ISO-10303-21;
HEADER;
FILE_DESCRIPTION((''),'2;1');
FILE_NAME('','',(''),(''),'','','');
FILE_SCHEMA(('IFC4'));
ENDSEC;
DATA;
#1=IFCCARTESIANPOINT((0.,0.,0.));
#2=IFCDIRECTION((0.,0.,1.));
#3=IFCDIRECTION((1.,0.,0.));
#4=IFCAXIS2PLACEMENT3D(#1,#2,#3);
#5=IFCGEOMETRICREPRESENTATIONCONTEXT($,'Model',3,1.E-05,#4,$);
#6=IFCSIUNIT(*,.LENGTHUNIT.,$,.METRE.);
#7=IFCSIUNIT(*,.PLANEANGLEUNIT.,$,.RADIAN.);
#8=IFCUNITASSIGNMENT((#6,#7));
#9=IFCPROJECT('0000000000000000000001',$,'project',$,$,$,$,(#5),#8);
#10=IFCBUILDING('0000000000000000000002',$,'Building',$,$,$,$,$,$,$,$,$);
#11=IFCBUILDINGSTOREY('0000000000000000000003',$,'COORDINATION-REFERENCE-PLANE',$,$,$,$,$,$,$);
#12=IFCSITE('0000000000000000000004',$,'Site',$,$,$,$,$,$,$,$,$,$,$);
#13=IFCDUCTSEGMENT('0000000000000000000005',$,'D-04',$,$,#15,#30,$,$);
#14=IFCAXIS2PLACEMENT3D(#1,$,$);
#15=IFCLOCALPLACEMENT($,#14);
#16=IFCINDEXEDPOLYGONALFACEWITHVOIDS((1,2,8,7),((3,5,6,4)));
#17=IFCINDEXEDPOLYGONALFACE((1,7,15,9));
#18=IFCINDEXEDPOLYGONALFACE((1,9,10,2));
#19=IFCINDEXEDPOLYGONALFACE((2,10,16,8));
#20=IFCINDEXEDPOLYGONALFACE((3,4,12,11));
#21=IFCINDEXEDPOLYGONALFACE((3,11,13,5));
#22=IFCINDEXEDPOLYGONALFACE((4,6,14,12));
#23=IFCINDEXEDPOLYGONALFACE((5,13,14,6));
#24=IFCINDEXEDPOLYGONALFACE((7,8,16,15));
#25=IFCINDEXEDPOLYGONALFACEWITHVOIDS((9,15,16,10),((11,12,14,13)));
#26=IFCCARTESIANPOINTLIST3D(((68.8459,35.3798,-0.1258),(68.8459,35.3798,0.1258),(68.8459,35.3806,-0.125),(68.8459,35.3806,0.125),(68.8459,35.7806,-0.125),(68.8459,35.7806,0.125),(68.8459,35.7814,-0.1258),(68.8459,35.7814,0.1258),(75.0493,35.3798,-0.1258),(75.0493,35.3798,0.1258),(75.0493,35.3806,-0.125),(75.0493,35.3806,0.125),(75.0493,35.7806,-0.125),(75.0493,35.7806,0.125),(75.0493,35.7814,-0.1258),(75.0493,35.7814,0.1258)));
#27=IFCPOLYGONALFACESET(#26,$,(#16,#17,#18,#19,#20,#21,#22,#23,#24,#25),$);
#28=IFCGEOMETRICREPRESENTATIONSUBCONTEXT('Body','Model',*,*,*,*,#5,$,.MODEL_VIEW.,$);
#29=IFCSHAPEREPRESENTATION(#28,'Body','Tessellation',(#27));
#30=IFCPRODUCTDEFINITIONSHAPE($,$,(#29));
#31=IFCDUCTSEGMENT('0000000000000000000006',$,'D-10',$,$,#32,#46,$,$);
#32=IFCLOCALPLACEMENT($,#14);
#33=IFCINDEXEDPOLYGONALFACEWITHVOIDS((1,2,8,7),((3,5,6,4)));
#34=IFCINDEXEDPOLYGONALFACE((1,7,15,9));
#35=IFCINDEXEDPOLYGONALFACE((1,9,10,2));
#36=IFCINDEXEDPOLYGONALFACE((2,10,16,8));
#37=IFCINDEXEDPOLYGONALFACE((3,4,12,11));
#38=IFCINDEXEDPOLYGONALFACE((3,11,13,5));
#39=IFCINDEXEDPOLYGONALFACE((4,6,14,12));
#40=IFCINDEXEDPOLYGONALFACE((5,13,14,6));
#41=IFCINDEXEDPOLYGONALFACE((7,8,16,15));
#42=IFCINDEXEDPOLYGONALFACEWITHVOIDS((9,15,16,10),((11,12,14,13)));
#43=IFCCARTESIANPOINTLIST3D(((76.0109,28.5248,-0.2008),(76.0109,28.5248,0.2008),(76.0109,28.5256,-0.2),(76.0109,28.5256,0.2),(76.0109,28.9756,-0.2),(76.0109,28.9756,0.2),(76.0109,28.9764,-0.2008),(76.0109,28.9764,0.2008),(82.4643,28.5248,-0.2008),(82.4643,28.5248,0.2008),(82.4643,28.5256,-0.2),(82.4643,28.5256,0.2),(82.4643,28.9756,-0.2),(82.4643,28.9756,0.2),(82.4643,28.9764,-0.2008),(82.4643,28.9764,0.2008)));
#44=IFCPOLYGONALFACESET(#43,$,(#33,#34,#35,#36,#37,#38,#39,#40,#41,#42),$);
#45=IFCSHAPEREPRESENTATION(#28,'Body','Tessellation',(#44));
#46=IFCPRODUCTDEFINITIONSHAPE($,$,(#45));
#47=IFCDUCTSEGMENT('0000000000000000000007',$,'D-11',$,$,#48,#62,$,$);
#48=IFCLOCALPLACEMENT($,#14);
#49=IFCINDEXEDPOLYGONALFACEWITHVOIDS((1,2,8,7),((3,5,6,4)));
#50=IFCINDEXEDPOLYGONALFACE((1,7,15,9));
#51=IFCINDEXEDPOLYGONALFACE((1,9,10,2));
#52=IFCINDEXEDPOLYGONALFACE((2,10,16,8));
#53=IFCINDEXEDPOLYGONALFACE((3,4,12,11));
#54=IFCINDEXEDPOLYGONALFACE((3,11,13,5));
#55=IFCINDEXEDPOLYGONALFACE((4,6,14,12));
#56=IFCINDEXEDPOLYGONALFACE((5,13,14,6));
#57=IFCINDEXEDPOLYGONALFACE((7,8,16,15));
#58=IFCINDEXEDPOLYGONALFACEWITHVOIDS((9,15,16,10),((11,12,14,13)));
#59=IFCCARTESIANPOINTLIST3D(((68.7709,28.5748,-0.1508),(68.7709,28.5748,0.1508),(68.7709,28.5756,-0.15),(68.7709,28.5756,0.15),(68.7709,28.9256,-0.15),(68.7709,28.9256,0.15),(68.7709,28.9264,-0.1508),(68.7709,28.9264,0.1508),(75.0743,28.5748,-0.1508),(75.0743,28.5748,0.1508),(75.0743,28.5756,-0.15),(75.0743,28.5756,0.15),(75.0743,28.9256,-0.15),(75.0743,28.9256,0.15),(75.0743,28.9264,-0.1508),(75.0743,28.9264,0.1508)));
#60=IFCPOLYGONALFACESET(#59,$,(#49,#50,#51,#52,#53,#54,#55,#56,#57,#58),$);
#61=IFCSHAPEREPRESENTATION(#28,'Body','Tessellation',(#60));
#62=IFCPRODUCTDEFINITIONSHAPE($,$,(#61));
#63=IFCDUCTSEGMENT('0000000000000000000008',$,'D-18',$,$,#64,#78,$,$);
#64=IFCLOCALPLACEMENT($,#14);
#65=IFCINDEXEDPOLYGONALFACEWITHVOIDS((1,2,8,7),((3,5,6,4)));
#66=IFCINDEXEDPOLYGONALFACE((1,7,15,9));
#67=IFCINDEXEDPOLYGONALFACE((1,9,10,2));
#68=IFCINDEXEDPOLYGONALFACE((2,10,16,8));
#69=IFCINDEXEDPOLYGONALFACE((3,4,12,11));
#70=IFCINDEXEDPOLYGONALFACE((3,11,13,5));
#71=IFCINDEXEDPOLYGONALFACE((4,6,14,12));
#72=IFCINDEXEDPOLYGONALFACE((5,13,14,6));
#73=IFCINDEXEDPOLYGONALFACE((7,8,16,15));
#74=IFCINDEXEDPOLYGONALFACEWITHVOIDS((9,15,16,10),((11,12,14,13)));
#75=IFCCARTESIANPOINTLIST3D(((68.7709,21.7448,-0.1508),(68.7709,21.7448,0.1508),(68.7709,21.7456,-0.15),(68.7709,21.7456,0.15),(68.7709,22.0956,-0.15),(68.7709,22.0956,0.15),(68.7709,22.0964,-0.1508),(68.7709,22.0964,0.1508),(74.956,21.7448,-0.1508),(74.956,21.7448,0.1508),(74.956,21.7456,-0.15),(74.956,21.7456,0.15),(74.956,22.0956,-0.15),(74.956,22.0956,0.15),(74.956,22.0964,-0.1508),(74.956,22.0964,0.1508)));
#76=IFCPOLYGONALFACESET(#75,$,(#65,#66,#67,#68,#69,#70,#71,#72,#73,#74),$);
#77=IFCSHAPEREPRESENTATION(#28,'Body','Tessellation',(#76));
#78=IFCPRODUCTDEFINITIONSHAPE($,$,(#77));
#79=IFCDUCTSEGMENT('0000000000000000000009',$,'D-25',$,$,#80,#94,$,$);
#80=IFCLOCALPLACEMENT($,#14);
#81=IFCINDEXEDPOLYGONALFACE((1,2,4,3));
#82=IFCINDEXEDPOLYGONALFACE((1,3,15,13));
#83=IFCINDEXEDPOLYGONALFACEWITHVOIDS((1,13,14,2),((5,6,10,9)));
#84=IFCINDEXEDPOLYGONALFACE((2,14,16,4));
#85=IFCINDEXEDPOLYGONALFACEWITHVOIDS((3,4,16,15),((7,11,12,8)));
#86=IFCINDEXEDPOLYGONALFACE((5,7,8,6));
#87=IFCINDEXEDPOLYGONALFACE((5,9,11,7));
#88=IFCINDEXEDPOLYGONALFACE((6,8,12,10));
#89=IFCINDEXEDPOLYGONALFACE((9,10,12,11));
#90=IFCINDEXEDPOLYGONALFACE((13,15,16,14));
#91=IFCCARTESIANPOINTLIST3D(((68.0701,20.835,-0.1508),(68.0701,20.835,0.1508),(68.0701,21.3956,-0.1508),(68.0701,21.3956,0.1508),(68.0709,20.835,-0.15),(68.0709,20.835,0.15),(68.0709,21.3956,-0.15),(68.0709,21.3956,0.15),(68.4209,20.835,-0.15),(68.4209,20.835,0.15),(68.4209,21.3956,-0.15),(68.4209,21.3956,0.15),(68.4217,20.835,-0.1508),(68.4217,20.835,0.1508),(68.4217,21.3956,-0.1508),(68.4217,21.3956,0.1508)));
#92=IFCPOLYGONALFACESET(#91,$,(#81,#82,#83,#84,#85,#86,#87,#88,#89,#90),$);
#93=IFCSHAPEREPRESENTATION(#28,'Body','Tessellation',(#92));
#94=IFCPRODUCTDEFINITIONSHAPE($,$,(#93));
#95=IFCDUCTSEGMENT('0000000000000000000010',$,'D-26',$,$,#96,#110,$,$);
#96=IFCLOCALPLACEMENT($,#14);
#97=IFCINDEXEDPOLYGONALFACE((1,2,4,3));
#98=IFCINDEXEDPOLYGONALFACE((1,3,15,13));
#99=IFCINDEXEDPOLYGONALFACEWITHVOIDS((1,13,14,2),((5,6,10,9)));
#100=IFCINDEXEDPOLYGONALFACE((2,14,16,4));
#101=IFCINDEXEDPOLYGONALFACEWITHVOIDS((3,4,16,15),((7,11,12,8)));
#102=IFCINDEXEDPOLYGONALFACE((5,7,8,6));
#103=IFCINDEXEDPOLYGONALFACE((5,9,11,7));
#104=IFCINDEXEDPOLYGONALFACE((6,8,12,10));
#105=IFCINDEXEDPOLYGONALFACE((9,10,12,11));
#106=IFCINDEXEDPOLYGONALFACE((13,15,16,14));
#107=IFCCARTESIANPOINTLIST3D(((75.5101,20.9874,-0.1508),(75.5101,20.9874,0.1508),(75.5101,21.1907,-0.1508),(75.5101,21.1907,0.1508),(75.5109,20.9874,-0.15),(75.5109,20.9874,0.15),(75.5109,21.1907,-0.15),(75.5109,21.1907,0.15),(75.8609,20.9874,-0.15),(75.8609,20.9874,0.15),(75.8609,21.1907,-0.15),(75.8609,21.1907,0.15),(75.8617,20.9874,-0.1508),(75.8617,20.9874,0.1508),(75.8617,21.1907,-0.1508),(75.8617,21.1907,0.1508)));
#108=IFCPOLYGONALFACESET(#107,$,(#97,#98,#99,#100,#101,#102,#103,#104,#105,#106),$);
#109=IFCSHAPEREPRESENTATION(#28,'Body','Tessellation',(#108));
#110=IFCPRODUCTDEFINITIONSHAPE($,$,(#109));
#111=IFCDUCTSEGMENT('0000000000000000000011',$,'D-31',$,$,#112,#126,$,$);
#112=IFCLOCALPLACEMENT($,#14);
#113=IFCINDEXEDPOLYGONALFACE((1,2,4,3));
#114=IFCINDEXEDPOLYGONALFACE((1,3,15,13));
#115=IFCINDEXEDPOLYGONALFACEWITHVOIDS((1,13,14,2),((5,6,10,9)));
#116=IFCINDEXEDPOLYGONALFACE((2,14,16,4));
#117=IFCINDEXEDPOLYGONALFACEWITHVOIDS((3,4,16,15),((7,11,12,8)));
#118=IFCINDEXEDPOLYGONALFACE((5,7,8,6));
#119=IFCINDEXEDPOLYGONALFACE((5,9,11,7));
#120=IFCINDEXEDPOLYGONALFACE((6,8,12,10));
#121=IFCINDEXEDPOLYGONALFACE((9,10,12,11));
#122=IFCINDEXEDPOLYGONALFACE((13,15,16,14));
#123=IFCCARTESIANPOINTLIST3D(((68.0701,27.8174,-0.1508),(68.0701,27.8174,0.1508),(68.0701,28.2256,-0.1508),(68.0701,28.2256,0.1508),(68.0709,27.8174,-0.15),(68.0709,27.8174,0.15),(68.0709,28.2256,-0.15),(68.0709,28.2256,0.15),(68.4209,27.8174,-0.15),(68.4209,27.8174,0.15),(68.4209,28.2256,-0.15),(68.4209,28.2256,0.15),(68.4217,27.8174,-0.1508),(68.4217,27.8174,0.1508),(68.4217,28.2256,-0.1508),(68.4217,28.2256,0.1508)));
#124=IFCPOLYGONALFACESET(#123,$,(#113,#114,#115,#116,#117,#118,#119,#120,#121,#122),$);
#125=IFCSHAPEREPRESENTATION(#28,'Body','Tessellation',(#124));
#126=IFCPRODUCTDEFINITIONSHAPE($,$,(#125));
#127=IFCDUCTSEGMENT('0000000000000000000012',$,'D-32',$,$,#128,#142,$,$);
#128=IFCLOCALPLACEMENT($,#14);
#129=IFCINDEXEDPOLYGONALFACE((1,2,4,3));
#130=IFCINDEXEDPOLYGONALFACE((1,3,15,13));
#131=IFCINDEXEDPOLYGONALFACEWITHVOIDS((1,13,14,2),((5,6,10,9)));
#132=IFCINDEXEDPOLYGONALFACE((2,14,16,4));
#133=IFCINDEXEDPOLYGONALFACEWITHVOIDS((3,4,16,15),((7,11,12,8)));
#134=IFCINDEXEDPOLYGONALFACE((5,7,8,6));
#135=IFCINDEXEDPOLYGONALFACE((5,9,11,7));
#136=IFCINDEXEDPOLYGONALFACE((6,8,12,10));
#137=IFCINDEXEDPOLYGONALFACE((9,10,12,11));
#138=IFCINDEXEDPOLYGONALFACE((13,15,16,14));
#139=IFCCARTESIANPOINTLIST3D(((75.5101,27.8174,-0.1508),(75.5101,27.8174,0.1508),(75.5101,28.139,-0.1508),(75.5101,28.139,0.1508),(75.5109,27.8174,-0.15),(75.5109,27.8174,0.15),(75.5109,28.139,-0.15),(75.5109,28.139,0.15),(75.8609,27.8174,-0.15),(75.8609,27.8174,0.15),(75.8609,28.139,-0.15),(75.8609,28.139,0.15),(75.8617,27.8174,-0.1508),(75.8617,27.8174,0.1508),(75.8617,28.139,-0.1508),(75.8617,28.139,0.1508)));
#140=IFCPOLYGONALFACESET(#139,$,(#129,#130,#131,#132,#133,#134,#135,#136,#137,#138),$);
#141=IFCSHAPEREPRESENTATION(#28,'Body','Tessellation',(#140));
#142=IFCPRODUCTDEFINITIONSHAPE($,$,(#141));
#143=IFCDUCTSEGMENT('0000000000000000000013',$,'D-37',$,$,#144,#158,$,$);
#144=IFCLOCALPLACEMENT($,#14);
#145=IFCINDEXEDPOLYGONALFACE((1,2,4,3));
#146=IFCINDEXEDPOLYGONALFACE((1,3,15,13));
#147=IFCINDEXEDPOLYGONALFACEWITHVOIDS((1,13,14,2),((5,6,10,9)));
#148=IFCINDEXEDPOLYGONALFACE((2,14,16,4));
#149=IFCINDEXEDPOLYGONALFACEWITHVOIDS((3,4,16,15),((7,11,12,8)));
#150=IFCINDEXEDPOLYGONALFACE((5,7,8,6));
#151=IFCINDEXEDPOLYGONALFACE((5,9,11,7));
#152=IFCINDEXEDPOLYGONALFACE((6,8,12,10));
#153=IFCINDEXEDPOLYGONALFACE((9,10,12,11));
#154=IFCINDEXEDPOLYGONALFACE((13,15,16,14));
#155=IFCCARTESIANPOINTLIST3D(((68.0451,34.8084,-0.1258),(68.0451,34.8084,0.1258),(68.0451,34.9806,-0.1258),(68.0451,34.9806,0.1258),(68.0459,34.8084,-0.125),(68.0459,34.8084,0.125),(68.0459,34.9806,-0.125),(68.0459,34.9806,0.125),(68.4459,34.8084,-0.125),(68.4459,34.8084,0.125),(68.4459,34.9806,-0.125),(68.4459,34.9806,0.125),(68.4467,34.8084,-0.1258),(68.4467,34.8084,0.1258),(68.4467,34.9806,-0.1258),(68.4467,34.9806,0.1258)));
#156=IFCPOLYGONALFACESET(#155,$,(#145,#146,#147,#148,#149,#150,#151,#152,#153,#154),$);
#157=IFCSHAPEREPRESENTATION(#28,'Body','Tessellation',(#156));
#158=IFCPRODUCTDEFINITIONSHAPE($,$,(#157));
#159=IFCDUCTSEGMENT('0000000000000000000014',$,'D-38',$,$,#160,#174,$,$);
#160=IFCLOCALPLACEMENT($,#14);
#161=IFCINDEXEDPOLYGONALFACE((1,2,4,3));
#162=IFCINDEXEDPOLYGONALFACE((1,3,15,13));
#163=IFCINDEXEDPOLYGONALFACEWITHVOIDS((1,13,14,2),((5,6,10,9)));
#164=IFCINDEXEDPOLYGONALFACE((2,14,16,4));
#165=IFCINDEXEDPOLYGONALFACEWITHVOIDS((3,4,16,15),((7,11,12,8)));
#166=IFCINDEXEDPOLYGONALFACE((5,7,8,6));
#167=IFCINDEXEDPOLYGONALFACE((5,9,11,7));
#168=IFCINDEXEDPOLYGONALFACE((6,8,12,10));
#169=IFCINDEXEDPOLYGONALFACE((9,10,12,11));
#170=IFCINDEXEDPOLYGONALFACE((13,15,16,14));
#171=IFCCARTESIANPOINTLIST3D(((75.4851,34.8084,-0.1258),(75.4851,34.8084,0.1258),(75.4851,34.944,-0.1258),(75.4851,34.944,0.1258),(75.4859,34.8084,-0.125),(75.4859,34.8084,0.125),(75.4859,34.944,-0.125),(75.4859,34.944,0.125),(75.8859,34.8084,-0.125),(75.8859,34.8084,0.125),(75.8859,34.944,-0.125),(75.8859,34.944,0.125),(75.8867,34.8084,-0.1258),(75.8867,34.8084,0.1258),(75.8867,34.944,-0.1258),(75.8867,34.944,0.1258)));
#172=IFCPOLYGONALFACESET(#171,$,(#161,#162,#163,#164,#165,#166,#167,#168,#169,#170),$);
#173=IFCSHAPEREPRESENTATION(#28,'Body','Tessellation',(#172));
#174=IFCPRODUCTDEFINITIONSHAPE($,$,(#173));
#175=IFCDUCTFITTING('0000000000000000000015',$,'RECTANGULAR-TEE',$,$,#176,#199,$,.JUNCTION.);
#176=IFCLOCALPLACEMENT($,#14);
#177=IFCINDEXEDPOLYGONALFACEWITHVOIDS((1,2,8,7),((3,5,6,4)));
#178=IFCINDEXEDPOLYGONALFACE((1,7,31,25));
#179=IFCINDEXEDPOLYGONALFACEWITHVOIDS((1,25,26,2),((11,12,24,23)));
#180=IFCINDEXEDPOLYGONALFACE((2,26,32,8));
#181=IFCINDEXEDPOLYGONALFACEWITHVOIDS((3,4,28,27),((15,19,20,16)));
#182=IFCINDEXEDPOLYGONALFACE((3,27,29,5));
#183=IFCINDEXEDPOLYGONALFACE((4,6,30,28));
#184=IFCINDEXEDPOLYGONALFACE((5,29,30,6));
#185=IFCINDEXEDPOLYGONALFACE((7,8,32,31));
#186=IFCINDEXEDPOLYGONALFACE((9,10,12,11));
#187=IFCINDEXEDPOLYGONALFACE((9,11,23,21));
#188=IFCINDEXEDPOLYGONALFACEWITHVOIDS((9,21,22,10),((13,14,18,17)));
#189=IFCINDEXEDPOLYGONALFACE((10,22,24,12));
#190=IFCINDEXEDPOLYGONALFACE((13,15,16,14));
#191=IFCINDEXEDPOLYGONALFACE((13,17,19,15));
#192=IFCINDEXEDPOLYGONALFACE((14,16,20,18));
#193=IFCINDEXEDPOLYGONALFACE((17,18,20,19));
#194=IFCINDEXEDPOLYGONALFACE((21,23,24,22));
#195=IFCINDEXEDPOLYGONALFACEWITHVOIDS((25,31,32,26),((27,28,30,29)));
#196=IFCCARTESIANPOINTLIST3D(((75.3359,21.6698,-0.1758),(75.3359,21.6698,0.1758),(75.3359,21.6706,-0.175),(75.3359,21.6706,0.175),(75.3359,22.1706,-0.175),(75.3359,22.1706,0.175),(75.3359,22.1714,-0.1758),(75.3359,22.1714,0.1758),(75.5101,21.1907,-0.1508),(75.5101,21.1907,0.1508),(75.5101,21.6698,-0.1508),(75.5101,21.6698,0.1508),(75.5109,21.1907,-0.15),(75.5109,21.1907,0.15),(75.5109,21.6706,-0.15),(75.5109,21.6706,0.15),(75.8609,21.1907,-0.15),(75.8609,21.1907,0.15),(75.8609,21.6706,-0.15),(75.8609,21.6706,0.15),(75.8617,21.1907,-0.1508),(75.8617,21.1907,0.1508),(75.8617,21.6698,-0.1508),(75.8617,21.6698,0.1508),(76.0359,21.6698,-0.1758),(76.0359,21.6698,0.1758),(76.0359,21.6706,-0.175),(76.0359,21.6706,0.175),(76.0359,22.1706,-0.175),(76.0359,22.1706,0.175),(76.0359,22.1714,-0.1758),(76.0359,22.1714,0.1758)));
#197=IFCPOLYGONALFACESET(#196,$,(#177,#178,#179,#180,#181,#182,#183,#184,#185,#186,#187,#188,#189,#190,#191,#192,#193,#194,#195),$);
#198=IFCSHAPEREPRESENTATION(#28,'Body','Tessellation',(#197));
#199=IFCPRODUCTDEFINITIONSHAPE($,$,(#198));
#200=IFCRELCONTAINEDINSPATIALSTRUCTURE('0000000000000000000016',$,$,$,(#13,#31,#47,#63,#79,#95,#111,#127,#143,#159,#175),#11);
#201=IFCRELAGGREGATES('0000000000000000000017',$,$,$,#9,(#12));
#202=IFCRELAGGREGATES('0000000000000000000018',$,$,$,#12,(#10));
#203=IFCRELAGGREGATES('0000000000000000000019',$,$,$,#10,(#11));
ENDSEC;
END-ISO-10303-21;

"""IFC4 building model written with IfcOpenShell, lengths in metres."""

from ifc_helpers import new_model, si_unit, frame, origin, origin_with_axes, place, context, subcontext, project, spatial, rectangle, hollow_rectangle, extrude, boolean, element, save


model = new_model("IFC4")

# Units and contexts
model_context = context("Model", 3, precision=1e-05, world=origin_with_axes())
body_context_1 = subcontext(model_context, "Body", "Model", "MODEL_VIEW")
ifc_project = project(units=[si_unit("LENGTHUNIT", "METRE"), si_unit("PLANEANGLEUNIT", "RADIAN")], contexts=[model_context])

# Site, building, storey
site = spatial("IfcSite", under=ifc_project, Name="Site")
building = spatial("IfcBuilding", under=site, Name="Building")
storey = spatial("IfcBuildingStorey", under=building, Name="COORDINATION-REFERENCE-PLANE")

# Duct segments
duct_segment_1_placement = place(None, frame((68.8459, 35.5806, 0.0), z_axis=(1.0, 0.0, 0.0), x_axis=(0.0, 1.0, 0.0)))
element("IfcDuctSegment", 1, at=duct_segment_1_placement, inside=storey, Name="D-04", context=body_context_1, shape_type="SweptSolid", body=[
    extrude(hollow_rectangle(XDim=0.4016, YDim=0.2516, WallThickness=0.0008), origin(), (0.0, 0.0, 1.0), 6.2034),
])
duct_segment_2_placement = place(None, frame((76.0109, 28.7506, 0.0), z_axis=(1.0, 0.0, 0.0), x_axis=(0.0, 1.0, 0.0)))
element("IfcDuctSegment", 2, at=duct_segment_2_placement, inside=storey, Name="D-10", context=body_context_1, shape_type="SweptSolid", body=[
    extrude(hollow_rectangle(XDim=0.4516, YDim=0.4016, WallThickness=0.0008), origin(), (0.0, 0.0, 1.0), 6.4534),
])
duct_segment_3_placement = place(None, frame((68.7709, 28.7506, 0.0), z_axis=(1.0, 0.0, 0.0), x_axis=(0.0, 1.0, 0.0)))
element("IfcDuctSegment", 3, at=duct_segment_3_placement, inside=storey, Name="D-11", context=body_context_1, shape_type="SweptSolid", body=[
    extrude(hollow_rectangle(XDim=0.3516, YDim=0.3016, WallThickness=0.0008), origin(), (0.0, 0.0, 1.0), 6.3034),
])
duct_segment_4_placement = place(None, frame((68.7709, 21.9206, 0.0), z_axis=(1.0, 0.0, 0.0), x_axis=(0.0, 1.0, 0.0)))
element("IfcDuctSegment", 4, at=duct_segment_4_placement, inside=storey, Name="D-18", context=body_context_1, shape_type="SweptSolid", body=[
    extrude(hollow_rectangle(XDim=0.3516, YDim=0.3016, WallThickness=0.0008), origin(), (0.0, 0.0, 1.0), 6.1851),
])
duct_segment_5_placement = place(None, frame((68.2459, 20.835, 0.0), z_axis=(0.0, 1.0, 0.0), x_axis=(1.0, 0.0, 0.0)))
element("IfcDuctSegment", 5, at=duct_segment_5_placement, inside=storey, Name="D-25", context=body_context_1, shape_type="SweptSolid", body=[
    extrude(hollow_rectangle(XDim=0.3516, YDim=0.3016, WallThickness=0.0008), origin(), (0.0, 0.0, 1.0), 0.5606),
])
duct_segment_6_placement = place(None, frame((75.6859, 20.9874, 0.0), z_axis=(0.0, 1.0, 0.0), x_axis=(1.0, 0.0, 0.0)))
element("IfcDuctSegment", 6, at=duct_segment_6_placement, inside=storey, Name="D-26", context=body_context_1, shape_type="SweptSolid", body=[
    extrude(hollow_rectangle(XDim=0.3516, YDim=0.3016, WallThickness=0.0008), origin(), (0.0, 0.0, 1.0), 0.2033),
])
duct_segment_7_placement = place(None, frame((68.2459, 27.8174, 0.0), z_axis=(0.0, 1.0, 0.0), x_axis=(1.0, 0.0, 0.0)))
element("IfcDuctSegment", 7, at=duct_segment_7_placement, inside=storey, Name="D-31", context=body_context_1, shape_type="SweptSolid", body=[
    extrude(hollow_rectangle(XDim=0.3516, YDim=0.3016, WallThickness=0.0008), origin(), (0.0, 0.0, 1.0), 0.4082),
])
duct_segment_8_placement = place(None, frame((75.6859, 27.8174, 0.0), z_axis=(0.0, 1.0, 0.0), x_axis=(1.0, 0.0, 0.0)))
element("IfcDuctSegment", 8, at=duct_segment_8_placement, inside=storey, Name="D-32", context=body_context_1, shape_type="SweptSolid", body=[
    extrude(hollow_rectangle(XDim=0.3516, YDim=0.3016, WallThickness=0.0008), origin(), (0.0, 0.0, 1.0), 0.3216),
])
duct_segment_9_placement = place(None, frame((68.2459, 34.8084, 0.0), z_axis=(0.0, 1.0, 0.0), x_axis=(1.0, 0.0, 0.0)))
element("IfcDuctSegment", 9, at=duct_segment_9_placement, inside=storey, Name="D-37", context=body_context_1, shape_type="SweptSolid", body=[
    extrude(hollow_rectangle(XDim=0.4016, YDim=0.2516, WallThickness=0.0008), origin(), (0.0, 0.0, 1.0), 0.1721),
])
duct_segment_10_placement = place(None, frame((75.6859, 34.8084, 0.0), z_axis=(0.0, 1.0, 0.0), x_axis=(1.0, 0.0, 0.0)))
element("IfcDuctSegment", 10, at=duct_segment_10_placement, inside=storey, Name="D-38", context=body_context_1, shape_type="SweptSolid", body=[
    extrude(hollow_rectangle(XDim=0.4016, YDim=0.2516, WallThickness=0.0008), origin(), (0.0, 0.0, 1.0), 0.1355),
])

# Duct fitting
duct_fitting_1_placement = place(None, frame((75.6859, 21.9206, 0.0), z_axis=(-1.0, 0.0, 0.0), x_axis=(0.0, -1.0, 0.0)))
solid_1 = boolean("UNION", extrude(rectangle(XDim=0.5, YDim=0.35), frame((0.0, 0.0, -0.35), z_axis=(0.0, 0.0, 1.0), x_axis=(1.0, 0.0, 0.0)), (0.0, 0.0, 1.0), 0.7), extrude(rectangle(XDim=0.35, YDim=0.3), frame((0.0, 0.0, 0.0), z_axis=(1.0, 0.0, 0.0), x_axis=(0.0, 0.0, -1.0)), (0.0, 0.0, 1.0), 0.7299))
element("IfcDuctFitting", 11, at=duct_fitting_1_placement, inside=storey, Name="RECTANGULAR-TEE", PredefinedType="JUNCTION", context=body_context_1, shape_type="CSG", body=[
    boolean("DIFFERENCE", boolean("UNION", extrude(rectangle(XDim=0.5016, YDim=0.3516), frame((0.0, 0.0, -0.35), z_axis=(0.0, 0.0, 1.0), x_axis=(1.0, 0.0, 0.0)), (0.0, 0.0, 1.0), 0.7), extrude(rectangle(XDim=0.3516, YDim=0.3016), frame((0.0, 0.0, 0.0), z_axis=(1.0, 0.0, 0.0), x_axis=(0.0, 0.0, -1.0)), (0.0, 0.0, 1.0), 0.7299)), solid_1),
])

save(model, "model.ifc")
